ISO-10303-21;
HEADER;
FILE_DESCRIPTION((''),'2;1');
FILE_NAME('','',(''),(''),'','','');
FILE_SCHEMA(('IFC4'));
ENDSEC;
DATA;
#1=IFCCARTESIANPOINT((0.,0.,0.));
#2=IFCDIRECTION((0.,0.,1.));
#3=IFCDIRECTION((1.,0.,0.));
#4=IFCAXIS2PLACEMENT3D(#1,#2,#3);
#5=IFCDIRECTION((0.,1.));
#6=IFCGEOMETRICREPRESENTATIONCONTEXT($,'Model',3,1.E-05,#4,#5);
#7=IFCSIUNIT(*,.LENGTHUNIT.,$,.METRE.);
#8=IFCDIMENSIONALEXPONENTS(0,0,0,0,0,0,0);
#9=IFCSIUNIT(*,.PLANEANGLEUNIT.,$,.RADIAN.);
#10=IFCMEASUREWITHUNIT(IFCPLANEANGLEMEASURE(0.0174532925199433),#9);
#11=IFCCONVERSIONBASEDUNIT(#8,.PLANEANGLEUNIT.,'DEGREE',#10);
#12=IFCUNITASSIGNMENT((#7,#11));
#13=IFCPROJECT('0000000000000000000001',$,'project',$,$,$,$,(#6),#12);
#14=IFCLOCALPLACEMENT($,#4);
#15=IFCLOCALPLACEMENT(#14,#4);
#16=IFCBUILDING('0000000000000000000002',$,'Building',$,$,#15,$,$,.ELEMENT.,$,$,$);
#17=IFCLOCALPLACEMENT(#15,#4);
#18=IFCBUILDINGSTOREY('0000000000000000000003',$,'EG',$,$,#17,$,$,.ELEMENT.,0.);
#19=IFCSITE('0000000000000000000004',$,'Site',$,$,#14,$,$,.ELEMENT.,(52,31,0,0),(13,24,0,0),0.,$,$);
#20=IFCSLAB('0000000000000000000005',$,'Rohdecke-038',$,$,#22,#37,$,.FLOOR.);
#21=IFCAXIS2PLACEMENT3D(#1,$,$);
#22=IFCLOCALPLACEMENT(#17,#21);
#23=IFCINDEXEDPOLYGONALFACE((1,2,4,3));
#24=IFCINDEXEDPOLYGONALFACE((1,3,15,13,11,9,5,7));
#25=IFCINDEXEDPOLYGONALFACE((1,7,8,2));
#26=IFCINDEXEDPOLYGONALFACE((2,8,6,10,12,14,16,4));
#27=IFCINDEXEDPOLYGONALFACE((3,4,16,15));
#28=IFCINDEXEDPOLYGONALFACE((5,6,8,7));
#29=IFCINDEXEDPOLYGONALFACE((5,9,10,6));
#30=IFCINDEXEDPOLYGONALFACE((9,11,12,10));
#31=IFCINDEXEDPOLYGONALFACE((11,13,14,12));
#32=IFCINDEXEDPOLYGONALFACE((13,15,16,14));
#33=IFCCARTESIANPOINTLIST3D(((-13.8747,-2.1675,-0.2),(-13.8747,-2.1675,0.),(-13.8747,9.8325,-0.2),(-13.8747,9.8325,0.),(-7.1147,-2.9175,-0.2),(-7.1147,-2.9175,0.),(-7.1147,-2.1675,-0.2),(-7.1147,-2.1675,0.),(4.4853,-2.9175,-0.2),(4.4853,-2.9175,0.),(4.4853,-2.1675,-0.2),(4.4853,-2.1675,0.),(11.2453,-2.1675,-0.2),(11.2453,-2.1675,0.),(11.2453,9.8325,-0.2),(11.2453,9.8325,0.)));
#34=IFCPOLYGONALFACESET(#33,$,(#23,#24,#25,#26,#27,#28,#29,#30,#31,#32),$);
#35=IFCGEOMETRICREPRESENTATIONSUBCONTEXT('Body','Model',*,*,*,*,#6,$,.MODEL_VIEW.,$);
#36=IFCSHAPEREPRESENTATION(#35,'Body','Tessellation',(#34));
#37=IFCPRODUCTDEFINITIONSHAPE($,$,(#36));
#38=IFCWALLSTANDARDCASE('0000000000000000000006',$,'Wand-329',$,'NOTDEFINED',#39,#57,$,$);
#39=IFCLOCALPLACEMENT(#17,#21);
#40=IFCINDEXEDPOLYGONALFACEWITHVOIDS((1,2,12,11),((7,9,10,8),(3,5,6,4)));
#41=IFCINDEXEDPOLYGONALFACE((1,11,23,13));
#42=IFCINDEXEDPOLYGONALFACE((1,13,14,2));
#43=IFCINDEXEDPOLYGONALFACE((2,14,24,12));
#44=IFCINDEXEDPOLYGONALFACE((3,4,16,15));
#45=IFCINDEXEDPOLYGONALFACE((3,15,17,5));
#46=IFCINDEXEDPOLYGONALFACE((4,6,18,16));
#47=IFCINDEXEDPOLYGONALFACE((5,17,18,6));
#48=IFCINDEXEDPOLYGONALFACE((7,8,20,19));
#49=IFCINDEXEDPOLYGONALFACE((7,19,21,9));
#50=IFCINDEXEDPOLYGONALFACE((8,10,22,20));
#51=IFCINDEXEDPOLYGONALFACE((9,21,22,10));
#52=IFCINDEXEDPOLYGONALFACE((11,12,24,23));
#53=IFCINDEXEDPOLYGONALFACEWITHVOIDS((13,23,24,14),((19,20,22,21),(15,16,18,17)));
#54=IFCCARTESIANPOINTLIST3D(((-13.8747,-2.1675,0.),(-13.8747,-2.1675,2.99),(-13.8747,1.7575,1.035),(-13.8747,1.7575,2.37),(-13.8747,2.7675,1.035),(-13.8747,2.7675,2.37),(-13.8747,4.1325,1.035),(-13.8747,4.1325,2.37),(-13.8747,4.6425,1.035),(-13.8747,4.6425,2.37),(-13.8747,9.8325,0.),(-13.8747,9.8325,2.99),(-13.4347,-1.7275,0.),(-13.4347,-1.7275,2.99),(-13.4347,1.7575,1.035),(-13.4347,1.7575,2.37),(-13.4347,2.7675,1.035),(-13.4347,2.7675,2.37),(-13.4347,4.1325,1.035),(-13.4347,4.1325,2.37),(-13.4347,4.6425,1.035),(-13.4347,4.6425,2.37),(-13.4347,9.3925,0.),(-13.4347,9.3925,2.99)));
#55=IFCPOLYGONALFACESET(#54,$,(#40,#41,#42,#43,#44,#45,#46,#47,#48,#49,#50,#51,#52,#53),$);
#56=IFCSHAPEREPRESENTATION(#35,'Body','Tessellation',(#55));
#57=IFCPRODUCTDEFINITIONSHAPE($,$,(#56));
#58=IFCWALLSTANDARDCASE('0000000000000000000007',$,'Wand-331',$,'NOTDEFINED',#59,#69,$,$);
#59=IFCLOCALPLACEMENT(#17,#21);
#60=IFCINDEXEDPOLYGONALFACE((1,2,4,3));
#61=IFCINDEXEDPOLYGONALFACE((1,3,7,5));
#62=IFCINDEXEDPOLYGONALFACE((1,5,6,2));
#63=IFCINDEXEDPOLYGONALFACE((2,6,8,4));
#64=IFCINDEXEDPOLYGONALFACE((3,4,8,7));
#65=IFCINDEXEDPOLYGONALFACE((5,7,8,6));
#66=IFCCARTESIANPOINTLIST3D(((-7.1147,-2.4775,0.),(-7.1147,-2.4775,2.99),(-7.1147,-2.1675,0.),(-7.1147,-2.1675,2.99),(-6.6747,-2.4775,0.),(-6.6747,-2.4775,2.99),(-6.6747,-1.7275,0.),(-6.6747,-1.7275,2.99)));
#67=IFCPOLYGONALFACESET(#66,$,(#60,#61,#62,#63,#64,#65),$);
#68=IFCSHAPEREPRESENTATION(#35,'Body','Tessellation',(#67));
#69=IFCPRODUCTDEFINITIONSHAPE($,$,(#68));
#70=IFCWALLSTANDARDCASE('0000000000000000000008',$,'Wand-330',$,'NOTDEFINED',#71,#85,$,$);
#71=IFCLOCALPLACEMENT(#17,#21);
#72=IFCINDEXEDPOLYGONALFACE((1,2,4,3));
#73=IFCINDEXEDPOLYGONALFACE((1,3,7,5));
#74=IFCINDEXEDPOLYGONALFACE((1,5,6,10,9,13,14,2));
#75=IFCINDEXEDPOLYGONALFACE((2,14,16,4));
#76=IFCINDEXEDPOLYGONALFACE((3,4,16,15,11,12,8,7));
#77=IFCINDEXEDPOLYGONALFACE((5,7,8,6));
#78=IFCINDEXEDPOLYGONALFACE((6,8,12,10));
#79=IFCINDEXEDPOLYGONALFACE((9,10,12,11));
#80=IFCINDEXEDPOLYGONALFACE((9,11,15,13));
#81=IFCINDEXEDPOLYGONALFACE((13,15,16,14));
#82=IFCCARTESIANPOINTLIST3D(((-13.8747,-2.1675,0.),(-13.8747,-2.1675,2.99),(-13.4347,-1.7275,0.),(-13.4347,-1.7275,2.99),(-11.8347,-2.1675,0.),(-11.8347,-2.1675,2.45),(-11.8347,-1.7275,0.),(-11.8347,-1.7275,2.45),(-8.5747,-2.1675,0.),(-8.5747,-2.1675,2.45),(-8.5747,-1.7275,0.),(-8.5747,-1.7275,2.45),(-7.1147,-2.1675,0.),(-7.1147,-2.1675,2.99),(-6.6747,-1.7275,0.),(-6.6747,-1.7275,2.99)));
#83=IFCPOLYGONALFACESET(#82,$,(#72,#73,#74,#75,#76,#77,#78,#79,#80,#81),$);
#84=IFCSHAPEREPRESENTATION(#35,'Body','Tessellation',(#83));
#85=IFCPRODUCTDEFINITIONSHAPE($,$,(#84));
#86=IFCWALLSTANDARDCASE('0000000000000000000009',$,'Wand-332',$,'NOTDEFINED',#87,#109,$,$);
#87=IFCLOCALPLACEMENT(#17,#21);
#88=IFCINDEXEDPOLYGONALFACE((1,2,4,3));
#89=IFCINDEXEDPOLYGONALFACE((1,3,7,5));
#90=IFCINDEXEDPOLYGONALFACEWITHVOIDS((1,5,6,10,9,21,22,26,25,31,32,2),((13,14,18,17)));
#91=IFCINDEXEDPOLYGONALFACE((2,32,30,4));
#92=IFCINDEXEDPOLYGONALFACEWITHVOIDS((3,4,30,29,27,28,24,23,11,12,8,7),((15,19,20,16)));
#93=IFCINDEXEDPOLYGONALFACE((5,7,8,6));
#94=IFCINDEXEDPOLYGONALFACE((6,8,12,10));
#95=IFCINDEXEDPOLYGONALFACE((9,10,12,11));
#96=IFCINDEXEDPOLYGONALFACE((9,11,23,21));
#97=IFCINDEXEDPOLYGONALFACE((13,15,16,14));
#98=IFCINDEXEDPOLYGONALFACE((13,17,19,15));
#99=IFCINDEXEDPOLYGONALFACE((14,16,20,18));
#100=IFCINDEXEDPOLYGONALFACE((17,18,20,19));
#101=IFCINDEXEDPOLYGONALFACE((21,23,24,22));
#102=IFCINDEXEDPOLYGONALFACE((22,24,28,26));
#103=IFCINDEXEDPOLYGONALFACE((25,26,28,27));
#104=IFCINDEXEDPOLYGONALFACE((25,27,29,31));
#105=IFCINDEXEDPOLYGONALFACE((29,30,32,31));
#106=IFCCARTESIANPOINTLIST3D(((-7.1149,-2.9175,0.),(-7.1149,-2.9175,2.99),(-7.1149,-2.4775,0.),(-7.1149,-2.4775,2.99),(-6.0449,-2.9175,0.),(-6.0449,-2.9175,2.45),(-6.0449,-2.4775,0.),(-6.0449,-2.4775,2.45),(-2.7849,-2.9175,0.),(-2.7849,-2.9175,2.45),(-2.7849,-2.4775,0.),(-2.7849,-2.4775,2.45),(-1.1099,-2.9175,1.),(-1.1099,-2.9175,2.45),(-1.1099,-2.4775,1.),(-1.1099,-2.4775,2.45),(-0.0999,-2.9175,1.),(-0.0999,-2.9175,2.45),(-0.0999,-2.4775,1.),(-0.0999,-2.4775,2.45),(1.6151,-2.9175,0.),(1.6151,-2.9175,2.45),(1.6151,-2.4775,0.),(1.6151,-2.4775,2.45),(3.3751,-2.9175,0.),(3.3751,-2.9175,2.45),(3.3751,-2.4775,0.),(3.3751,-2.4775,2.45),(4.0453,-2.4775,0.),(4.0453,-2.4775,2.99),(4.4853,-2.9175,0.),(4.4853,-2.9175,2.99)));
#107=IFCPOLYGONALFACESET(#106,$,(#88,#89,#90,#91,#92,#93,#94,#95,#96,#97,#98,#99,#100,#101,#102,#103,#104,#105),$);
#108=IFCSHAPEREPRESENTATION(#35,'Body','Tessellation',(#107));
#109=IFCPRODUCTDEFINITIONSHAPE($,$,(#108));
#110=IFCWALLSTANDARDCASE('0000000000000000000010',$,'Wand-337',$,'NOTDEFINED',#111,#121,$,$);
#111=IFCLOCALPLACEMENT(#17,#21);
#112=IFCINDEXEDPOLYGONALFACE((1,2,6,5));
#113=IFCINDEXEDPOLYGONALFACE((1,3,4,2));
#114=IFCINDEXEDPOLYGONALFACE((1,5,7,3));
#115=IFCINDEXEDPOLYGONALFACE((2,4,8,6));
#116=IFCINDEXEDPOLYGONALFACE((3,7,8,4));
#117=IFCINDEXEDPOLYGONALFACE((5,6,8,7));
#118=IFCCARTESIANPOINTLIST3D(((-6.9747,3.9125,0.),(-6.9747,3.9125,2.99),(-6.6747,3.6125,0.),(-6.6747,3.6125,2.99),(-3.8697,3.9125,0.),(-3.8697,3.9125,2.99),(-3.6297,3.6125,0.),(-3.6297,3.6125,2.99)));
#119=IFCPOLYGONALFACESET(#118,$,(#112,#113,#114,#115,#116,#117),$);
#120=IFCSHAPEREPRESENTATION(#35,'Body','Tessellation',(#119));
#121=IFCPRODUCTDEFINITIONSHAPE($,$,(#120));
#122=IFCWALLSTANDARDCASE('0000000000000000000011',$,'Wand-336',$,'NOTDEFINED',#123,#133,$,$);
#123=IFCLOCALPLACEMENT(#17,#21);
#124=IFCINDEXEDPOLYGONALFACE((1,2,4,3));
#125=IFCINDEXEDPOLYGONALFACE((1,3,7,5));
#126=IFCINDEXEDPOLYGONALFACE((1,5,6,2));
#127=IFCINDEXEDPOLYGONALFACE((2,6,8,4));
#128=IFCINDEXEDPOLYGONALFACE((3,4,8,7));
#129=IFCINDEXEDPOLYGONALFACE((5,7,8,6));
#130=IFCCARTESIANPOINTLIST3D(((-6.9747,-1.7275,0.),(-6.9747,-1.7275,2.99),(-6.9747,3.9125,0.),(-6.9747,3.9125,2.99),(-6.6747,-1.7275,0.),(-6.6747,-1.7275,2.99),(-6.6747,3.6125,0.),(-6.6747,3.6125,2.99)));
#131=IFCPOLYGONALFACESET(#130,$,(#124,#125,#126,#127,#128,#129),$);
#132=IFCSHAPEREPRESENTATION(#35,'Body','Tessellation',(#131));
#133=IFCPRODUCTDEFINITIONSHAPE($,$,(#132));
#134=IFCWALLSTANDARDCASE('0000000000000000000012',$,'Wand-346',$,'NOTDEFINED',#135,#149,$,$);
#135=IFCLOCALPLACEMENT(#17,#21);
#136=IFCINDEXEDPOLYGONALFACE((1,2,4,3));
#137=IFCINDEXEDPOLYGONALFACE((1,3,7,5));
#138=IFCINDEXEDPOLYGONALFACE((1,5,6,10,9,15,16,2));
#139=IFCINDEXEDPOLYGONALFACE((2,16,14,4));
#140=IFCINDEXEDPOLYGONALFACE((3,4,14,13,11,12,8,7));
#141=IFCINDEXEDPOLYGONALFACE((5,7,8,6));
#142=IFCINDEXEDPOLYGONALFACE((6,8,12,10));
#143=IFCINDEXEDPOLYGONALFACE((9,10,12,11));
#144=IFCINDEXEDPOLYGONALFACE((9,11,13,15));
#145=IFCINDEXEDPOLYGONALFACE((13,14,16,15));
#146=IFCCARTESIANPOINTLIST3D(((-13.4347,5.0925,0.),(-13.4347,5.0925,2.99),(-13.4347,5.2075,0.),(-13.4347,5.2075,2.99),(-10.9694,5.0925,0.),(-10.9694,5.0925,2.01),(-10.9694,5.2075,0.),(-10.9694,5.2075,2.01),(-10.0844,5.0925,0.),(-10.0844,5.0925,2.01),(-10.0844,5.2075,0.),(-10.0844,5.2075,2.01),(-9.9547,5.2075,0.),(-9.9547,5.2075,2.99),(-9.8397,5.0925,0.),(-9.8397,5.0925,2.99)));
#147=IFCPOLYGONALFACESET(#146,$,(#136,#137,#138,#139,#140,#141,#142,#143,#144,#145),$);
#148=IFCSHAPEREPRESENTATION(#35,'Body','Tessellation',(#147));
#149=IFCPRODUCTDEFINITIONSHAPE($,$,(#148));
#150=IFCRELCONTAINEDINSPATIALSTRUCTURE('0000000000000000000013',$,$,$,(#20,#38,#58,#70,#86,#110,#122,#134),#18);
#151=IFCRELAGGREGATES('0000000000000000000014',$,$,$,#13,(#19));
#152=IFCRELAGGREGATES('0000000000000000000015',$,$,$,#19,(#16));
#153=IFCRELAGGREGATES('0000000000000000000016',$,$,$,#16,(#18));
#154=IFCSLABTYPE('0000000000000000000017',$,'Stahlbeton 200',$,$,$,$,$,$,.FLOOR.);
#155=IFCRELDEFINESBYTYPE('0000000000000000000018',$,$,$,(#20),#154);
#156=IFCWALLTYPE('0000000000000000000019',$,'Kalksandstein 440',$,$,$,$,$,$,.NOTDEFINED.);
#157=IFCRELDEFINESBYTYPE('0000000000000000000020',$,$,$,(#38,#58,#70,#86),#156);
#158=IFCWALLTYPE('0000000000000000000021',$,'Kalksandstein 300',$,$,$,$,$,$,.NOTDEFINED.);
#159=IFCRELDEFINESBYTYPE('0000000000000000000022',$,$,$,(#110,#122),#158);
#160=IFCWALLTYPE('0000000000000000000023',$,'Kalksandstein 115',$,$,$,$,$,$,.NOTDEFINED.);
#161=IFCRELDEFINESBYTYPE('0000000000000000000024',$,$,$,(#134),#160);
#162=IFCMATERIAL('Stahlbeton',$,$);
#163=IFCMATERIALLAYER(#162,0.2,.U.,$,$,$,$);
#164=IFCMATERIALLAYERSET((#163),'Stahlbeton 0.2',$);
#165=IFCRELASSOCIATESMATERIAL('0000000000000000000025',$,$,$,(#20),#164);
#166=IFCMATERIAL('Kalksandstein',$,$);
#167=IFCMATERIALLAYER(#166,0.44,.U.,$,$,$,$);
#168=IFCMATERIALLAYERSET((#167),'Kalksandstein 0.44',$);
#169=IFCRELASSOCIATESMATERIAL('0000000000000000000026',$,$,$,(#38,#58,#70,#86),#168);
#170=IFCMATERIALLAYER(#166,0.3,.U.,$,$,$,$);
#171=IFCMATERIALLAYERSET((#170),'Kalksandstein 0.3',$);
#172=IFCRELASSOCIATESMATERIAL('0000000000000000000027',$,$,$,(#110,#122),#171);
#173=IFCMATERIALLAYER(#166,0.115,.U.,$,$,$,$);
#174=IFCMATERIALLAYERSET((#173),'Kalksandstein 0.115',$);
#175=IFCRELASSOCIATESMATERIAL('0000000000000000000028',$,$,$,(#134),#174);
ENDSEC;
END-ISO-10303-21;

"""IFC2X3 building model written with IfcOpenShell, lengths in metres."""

from ifc_helpers import new_model, entity, si_unit, converted_unit, direction, frame, origin_with_axes, origin_2d_with_axis, place, context, subcontext, project, spatial, polyline, rectangle, outline, extrude, material, layer, layer_set, layer_usage, type_object, element, save


model = new_model("IFC2X3")

# Units and contexts
model_context = context("Model", 3, precision=1e-05, world=origin_with_axes(), true_north=direction((0.0, 1.0)))
body_context = subcontext(model_context, "Body", "Model", "MODEL_VIEW")
ifc_project = project(units=[si_unit("LENGTHUNIT", "METRE"), converted_unit("PLANEANGLEUNIT", "DEGREE", entity("IfcPlaneAngleMeasure", 0.0174532925199433), si_unit("PLANEANGLEUNIT", "RADIAN"), dimensions=[0, 0, 0, 0, 0, 0, 0])], contexts=[model_context])

# Site, building, storey
site_placement = place(None, origin_with_axes())
site = spatial("IfcSite", under=ifc_project, at=site_placement, Name="Site", CompositionType="ELEMENT", RefLatitude=(52, 31, 0, 0), RefLongitude=(13, 24, 0, 0), RefElevation=0.0)
building_placement = place(site_placement, origin_with_axes())
building = spatial("IfcBuilding", under=site, at=building_placement, Name="Building", CompositionType="ELEMENT")
storey_placement = place(building_placement, origin_with_axes())
storey = spatial("IfcBuildingStorey", under=building, at=storey_placement, Name="EG", CompositionType="ELEMENT", Elevation=0.0)

# Slab
ifc_material_1 = material(Name="Stahlbeton")
ifc_layer_1 = layer(ifc_material_1, 0.2, ventilated="UNKNOWN")
ifc_layer_set_1 = layer_set([ifc_layer_1], Name="Stahlbeton 0.2")
ifc_layer_usage_1 = layer_usage(ifc_layer_set_1, "AXIS3", "NEGATIVE", 0.2)
slab_type = type_object("IfcSlabType", Name="Stahlbeton 200", PredefinedType="FLOOR")
slab_placement = place(storey_placement, frame((-13.8747, -2.1675, 0.0), z_axis=(0.0, 0.0, 1.0), x_axis=(1.0, 0.0, 0.0)))
element("IfcSlab", 1, at=slab_placement, inside=storey, type_object=slab_type, material=ifc_layer_usage_1, Name="Rohdecke-038", PredefinedType="FLOOR", context=body_context, shape_type="SweptSolid", body=[
    extrude(outline(polyline([(0.0, 0.0), (6.76, 0.0), (6.76, -0.75), (18.36, -0.75), (18.36, 0.0), (25.12, 0.0), (25.12, 12.0), (0.0, 12.0), (0.0, 0.0)])), frame((0.0, 0.0, -0.2), z_axis=(0.0, 0.0, 1.0), x_axis=(1.0, 0.0, 0.0)), (0.0, 0.0, 1.0), 0.2),
])

# Wall, openings
ifc_material_2 = material(Name="Kalksandstein")
ifc_layer_2 = layer(ifc_material_2, 0.44, ventilated="UNKNOWN")
ifc_layer_set_2 = layer_set([ifc_layer_2], Name="Kalksandstein 0.44")
ifc_layer_usage_2 = layer_usage(ifc_layer_set_2, "AXIS2", "NEGATIVE", 0.44)
wall_type_1 = type_object("IfcWallType", Name="Kalksandstein 440", PredefinedType="NOTDEFINED")
wall_1_placement = place(storey_placement, frame((-13.8747, 9.8325, 0.0), z_axis=(0.0, 0.0, 1.0), x_axis=(0.0, -1.0, 0.0)))
wall_1 = element("IfcWallStandardCase", 2, at=wall_1_placement, inside=storey, type_object=wall_type_1, material=ifc_layer_usage_2, Name="Wand-329", ObjectType="NOTDEFINED", context=body_context, shape_type="SweptSolid", body=[
    extrude(outline(polyline([(0.0, 0.0), (12.0, 0.0), (11.56, 0.44), (0.44, 0.44), (0.0, 0.0)])), origin_with_axes(), (0.0, 0.0, 1.0), 2.99),
])
opening_1_placement = place(wall_1_placement, frame((5.445, 0.0, 1.035), z_axis=(0.0, 0.0, 1.0), x_axis=(1.0, 0.0, 0.0)))
element("IfcOpeningElement", 3, at=opening_1_placement, cuts=wall_1, context=body_context, shape_type="SweptSolid", body=[
    extrude(rectangle(XDim=0.51, YDim=1.335, at=origin_2d_with_axis()), frame((0.0, 0.44, 0.6675), z_axis=(0.0, -1.0, 0.0), x_axis=(-1.0, 0.0, 0.0)), (0.0, 0.0, 1.0), 1.32),
])
opening_2_placement = place(wall_1_placement, frame((7.57, 0.0, 1.035), z_axis=(0.0, 0.0, 1.0), x_axis=(1.0, 0.0, 0.0)))
element("IfcOpeningElement", 4, at=opening_2_placement, cuts=wall_1, context=body_context, shape_type="SweptSolid", body=[
    extrude(rectangle(XDim=1.01, YDim=1.335, at=origin_2d_with_axis()), frame((0.0, 0.44, 0.6675), z_axis=(0.0, -1.0, 0.0), x_axis=(-1.0, 0.0, 0.0)), (0.0, 0.0, 1.0), 1.32),
])

# Wall
ifc_layer_usage_3 = layer_usage(ifc_layer_set_2, "AXIS2", "NEGATIVE", 0.44)
wall_2_placement = place(storey_placement, frame((-7.1147, -2.1675, 0.0), z_axis=(0.0, 0.0, 1.0), x_axis=(0.0, -1.0, 0.0)))
element("IfcWallStandardCase", 5, at=wall_2_placement, inside=storey, type_object=wall_type_1, material=ifc_layer_usage_3, Name="Wand-331", ObjectType="NOTDEFINED", context=body_context, shape_type="SweptSolid", body=[
    extrude(outline(polyline([(0.0, 0.0), (0.31, 0.0), (0.31, 0.44), (-0.44, 0.44), (0.0, 0.0)])), origin_with_axes(), (0.0, 0.0, 1.0), 2.99),
])

# Wall, opening
ifc_layer_usage_4 = layer_usage(ifc_layer_set_2, "AXIS2", "NEGATIVE", 0.44)
wall_3_placement = place(storey_placement, frame((-13.8747, -2.1675, 0.0), z_axis=(0.0, 0.0, 1.0), x_axis=(1.0, 0.0, 0.0)))
wall_3 = element("IfcWallStandardCase", 6, at=wall_3_placement, inside=storey, type_object=wall_type_1, material=ifc_layer_usage_4, Name="Wand-330", ObjectType="NOTDEFINED", context=body_context, shape_type="SweptSolid", body=[
    extrude(outline(polyline([(0.0, 0.0), (6.76, 0.0), (7.2, 0.44), (0.44, 0.44), (0.0, 0.0)])), origin_with_axes(), (0.0, 0.0, 1.0), 2.99),
])
opening_3_placement = place(wall_3_placement, frame((3.67, 0.0, 0.0), z_axis=(0.0, 0.0, 1.0), x_axis=(1.0, 0.0, 0.0)))
element("IfcOpeningElement", 7, at=opening_3_placement, cuts=wall_3, context=body_context, shape_type="SweptSolid", body=[
    extrude(rectangle(XDim=3.26, YDim=2.45, at=origin_2d_with_axis()), frame((0.0, 0.44, 1.225), z_axis=(0.0, -1.0, 0.0), x_axis=(-1.0, 0.0, 0.0)), (0.0, 0.0, 1.0), 1.32),
])

# Wall, openings
ifc_layer_usage_5 = layer_usage(ifc_layer_set_2, "AXIS2", "NEGATIVE", 0.44)
wall_4_placement = place(storey_placement, frame((-7.1149, -2.9175, 0.0), z_axis=(0.0, 0.0, 1.0), x_axis=(1.0, 0.0, 0.0)))
wall_4 = element("IfcWallStandardCase", 8, at=wall_4_placement, inside=storey, type_object=wall_type_1, material=ifc_layer_usage_5, Name="Wand-332", ObjectType="NOTDEFINED", context=body_context, shape_type="SweptSolid", body=[
    extrude(outline(polyline([(0.0, 0.0), (11.6002, 0.0), (11.1602, 0.44), (0.0, 0.44), (0.0, 0.0)])), origin_with_axes(), (0.0, 0.0, 1.0), 2.99),
])
opening_4_placement = place(wall_4_placement, frame((6.51, 0.0, 1.0), z_axis=(0.0, 0.0, 1.0), x_axis=(1.0, 0.0, 0.0)))
element("IfcOpeningElement", 9, at=opening_4_placement, cuts=wall_4, context=body_context, shape_type="SweptSolid", body=[
    extrude(rectangle(XDim=1.01, YDim=1.45, at=origin_2d_with_axis()), frame((0.0, 0.44, 0.725), z_axis=(0.0, -1.0, 0.0), x_axis=(-1.0, 0.0, 0.0)), (0.0, 0.0, 1.0), 1.32),
])
opening_5_placement = place(wall_4_placement, frame((2.7, 0.0, 0.0), z_axis=(0.0, 0.0, 1.0), x_axis=(1.0, 0.0, 0.0)))
element("IfcOpeningElement", 10, at=opening_5_placement, cuts=wall_4, context=body_context, shape_type="SweptSolid", body=[
    extrude(rectangle(XDim=3.26, YDim=2.45, at=origin_2d_with_axis()), frame((0.0, 0.44, 1.225), z_axis=(0.0, -1.0, 0.0), x_axis=(-1.0, 0.0, 0.0)), (0.0, 0.0, 1.0), 1.32),
])
opening_6_placement = place(wall_4_placement, frame((9.61, 0.0, 0.0), z_axis=(0.0, 0.0, 1.0), x_axis=(1.0, 0.0, 0.0)))
element("IfcOpeningElement", 11, at=opening_6_placement, cuts=wall_4, context=body_context, shape_type="SweptSolid", body=[
    extrude(rectangle(XDim=1.76, YDim=2.45, at=origin_2d_with_axis()), frame((0.0, 0.44, 1.225), z_axis=(0.0, -1.0, 0.0), x_axis=(-1.0, 0.0, 0.0)), (0.0, 0.0, 1.0), 1.32),
])

# Walls
ifc_layer_3 = layer(ifc_material_2, 0.3, ventilated="UNKNOWN")
ifc_layer_set_3 = layer_set([ifc_layer_3], Name="Kalksandstein 0.3")
ifc_layer_usage_6 = layer_usage(ifc_layer_set_3, "AXIS2", "NEGATIVE", 0.3)
wall_type_2 = type_object("IfcWallType", Name="Kalksandstein 300", PredefinedType="NOTDEFINED")
wall_5_placement = place(storey_placement, frame((-6.9747, 3.6125, 0.0), z_axis=(0.0, 0.0, 1.0), x_axis=(1.0, 0.0, 0.0)))
element("IfcWallStandardCase", 12, at=wall_5_placement, inside=storey, type_object=wall_type_2, material=ifc_layer_usage_6, Name="Wand-337", ObjectType="NOTDEFINED", context=body_context, shape_type="SweptSolid", body=[
    extrude(outline(polyline([(0.3, 0.0), (3.345, 0.0), (3.105, 0.3), (0.0, 0.3), (0.3, 0.0)])), origin_with_axes(), (0.0, 0.0, 1.0), 2.99),
])
ifc_layer_usage_7 = layer_usage(ifc_layer_set_3, "AXIS2", "POSITIVE", -0.3)
wall_6_placement = place(storey_placement, frame((-6.9747, -1.7275, 0.0), z_axis=(0.0, 0.0, 1.0), x_axis=(0.0, 1.0, 0.0)))
element("IfcWallStandardCase", 13, at=wall_6_placement, inside=storey, type_object=wall_type_2, material=ifc_layer_usage_7, Name="Wand-336", ObjectType="NOTDEFINED", context=body_context, shape_type="SweptSolid", body=[
    extrude(outline(polyline([(0.0, -0.3), (5.34, -0.3), (5.64, 0.0), (0.0, 0.0), (0.0, -0.3)])), origin_with_axes(), (0.0, 0.0, 1.0), 2.99),
])
ifc_layer_4 = layer(ifc_material_2, 0.115, ventilated="UNKNOWN")
ifc_layer_set_4 = layer_set([ifc_layer_4], Name="Kalksandstein 0.115")
wall_type_3 = type_object("IfcWallType", Name="Kalksandstein 115", PredefinedType="NOTDEFINED")

# Wall, opening
ifc_layer_usage_8 = layer_usage(ifc_layer_set_4, "AXIS2", "POSITIVE", -0.115)
wall_7_placement = place(storey_placement, frame((-9.9547, 5.0925, 0.0), z_axis=(0.0, 0.0, 1.0), x_axis=(-1.0, 0.0, 0.0)))
wall_7 = element("IfcWallStandardCase", 14, at=wall_7_placement, inside=storey, type_object=wall_type_3, material=ifc_layer_usage_8, Name="Wand-346", ObjectType="NOTDEFINED", context=body_context, shape_type="SweptSolid", body=[
    extrude(outline(polyline([(0.0, -0.115), (3.48, -0.115), (3.48, 0.0), (-0.115, 0.0), (0.0, -0.115)])), origin_with_axes(), (0.0, 0.0, 1.0), 2.99),
])
opening_7_placement = place(wall_7_placement, frame((0.5722, 0.0, 0.0), z_axis=(0.0, 0.0, 1.0), x_axis=(1.0, 0.0, 0.0)))
element("IfcOpeningElement", 15, at=opening_7_placement, cuts=wall_7, context=body_context, shape_type="SweptSolid", body=[
    extrude(rectangle(XDim=0.885, YDim=2.01, at=origin_2d_with_axis()), frame((0.0, 0.115, 1.005), z_axis=(0.0, -1.0, 0.0), x_axis=(-1.0, 0.0, 0.0)), (0.0, 0.0, 1.0), 0.345),
])

save(model, "model.ifc")
